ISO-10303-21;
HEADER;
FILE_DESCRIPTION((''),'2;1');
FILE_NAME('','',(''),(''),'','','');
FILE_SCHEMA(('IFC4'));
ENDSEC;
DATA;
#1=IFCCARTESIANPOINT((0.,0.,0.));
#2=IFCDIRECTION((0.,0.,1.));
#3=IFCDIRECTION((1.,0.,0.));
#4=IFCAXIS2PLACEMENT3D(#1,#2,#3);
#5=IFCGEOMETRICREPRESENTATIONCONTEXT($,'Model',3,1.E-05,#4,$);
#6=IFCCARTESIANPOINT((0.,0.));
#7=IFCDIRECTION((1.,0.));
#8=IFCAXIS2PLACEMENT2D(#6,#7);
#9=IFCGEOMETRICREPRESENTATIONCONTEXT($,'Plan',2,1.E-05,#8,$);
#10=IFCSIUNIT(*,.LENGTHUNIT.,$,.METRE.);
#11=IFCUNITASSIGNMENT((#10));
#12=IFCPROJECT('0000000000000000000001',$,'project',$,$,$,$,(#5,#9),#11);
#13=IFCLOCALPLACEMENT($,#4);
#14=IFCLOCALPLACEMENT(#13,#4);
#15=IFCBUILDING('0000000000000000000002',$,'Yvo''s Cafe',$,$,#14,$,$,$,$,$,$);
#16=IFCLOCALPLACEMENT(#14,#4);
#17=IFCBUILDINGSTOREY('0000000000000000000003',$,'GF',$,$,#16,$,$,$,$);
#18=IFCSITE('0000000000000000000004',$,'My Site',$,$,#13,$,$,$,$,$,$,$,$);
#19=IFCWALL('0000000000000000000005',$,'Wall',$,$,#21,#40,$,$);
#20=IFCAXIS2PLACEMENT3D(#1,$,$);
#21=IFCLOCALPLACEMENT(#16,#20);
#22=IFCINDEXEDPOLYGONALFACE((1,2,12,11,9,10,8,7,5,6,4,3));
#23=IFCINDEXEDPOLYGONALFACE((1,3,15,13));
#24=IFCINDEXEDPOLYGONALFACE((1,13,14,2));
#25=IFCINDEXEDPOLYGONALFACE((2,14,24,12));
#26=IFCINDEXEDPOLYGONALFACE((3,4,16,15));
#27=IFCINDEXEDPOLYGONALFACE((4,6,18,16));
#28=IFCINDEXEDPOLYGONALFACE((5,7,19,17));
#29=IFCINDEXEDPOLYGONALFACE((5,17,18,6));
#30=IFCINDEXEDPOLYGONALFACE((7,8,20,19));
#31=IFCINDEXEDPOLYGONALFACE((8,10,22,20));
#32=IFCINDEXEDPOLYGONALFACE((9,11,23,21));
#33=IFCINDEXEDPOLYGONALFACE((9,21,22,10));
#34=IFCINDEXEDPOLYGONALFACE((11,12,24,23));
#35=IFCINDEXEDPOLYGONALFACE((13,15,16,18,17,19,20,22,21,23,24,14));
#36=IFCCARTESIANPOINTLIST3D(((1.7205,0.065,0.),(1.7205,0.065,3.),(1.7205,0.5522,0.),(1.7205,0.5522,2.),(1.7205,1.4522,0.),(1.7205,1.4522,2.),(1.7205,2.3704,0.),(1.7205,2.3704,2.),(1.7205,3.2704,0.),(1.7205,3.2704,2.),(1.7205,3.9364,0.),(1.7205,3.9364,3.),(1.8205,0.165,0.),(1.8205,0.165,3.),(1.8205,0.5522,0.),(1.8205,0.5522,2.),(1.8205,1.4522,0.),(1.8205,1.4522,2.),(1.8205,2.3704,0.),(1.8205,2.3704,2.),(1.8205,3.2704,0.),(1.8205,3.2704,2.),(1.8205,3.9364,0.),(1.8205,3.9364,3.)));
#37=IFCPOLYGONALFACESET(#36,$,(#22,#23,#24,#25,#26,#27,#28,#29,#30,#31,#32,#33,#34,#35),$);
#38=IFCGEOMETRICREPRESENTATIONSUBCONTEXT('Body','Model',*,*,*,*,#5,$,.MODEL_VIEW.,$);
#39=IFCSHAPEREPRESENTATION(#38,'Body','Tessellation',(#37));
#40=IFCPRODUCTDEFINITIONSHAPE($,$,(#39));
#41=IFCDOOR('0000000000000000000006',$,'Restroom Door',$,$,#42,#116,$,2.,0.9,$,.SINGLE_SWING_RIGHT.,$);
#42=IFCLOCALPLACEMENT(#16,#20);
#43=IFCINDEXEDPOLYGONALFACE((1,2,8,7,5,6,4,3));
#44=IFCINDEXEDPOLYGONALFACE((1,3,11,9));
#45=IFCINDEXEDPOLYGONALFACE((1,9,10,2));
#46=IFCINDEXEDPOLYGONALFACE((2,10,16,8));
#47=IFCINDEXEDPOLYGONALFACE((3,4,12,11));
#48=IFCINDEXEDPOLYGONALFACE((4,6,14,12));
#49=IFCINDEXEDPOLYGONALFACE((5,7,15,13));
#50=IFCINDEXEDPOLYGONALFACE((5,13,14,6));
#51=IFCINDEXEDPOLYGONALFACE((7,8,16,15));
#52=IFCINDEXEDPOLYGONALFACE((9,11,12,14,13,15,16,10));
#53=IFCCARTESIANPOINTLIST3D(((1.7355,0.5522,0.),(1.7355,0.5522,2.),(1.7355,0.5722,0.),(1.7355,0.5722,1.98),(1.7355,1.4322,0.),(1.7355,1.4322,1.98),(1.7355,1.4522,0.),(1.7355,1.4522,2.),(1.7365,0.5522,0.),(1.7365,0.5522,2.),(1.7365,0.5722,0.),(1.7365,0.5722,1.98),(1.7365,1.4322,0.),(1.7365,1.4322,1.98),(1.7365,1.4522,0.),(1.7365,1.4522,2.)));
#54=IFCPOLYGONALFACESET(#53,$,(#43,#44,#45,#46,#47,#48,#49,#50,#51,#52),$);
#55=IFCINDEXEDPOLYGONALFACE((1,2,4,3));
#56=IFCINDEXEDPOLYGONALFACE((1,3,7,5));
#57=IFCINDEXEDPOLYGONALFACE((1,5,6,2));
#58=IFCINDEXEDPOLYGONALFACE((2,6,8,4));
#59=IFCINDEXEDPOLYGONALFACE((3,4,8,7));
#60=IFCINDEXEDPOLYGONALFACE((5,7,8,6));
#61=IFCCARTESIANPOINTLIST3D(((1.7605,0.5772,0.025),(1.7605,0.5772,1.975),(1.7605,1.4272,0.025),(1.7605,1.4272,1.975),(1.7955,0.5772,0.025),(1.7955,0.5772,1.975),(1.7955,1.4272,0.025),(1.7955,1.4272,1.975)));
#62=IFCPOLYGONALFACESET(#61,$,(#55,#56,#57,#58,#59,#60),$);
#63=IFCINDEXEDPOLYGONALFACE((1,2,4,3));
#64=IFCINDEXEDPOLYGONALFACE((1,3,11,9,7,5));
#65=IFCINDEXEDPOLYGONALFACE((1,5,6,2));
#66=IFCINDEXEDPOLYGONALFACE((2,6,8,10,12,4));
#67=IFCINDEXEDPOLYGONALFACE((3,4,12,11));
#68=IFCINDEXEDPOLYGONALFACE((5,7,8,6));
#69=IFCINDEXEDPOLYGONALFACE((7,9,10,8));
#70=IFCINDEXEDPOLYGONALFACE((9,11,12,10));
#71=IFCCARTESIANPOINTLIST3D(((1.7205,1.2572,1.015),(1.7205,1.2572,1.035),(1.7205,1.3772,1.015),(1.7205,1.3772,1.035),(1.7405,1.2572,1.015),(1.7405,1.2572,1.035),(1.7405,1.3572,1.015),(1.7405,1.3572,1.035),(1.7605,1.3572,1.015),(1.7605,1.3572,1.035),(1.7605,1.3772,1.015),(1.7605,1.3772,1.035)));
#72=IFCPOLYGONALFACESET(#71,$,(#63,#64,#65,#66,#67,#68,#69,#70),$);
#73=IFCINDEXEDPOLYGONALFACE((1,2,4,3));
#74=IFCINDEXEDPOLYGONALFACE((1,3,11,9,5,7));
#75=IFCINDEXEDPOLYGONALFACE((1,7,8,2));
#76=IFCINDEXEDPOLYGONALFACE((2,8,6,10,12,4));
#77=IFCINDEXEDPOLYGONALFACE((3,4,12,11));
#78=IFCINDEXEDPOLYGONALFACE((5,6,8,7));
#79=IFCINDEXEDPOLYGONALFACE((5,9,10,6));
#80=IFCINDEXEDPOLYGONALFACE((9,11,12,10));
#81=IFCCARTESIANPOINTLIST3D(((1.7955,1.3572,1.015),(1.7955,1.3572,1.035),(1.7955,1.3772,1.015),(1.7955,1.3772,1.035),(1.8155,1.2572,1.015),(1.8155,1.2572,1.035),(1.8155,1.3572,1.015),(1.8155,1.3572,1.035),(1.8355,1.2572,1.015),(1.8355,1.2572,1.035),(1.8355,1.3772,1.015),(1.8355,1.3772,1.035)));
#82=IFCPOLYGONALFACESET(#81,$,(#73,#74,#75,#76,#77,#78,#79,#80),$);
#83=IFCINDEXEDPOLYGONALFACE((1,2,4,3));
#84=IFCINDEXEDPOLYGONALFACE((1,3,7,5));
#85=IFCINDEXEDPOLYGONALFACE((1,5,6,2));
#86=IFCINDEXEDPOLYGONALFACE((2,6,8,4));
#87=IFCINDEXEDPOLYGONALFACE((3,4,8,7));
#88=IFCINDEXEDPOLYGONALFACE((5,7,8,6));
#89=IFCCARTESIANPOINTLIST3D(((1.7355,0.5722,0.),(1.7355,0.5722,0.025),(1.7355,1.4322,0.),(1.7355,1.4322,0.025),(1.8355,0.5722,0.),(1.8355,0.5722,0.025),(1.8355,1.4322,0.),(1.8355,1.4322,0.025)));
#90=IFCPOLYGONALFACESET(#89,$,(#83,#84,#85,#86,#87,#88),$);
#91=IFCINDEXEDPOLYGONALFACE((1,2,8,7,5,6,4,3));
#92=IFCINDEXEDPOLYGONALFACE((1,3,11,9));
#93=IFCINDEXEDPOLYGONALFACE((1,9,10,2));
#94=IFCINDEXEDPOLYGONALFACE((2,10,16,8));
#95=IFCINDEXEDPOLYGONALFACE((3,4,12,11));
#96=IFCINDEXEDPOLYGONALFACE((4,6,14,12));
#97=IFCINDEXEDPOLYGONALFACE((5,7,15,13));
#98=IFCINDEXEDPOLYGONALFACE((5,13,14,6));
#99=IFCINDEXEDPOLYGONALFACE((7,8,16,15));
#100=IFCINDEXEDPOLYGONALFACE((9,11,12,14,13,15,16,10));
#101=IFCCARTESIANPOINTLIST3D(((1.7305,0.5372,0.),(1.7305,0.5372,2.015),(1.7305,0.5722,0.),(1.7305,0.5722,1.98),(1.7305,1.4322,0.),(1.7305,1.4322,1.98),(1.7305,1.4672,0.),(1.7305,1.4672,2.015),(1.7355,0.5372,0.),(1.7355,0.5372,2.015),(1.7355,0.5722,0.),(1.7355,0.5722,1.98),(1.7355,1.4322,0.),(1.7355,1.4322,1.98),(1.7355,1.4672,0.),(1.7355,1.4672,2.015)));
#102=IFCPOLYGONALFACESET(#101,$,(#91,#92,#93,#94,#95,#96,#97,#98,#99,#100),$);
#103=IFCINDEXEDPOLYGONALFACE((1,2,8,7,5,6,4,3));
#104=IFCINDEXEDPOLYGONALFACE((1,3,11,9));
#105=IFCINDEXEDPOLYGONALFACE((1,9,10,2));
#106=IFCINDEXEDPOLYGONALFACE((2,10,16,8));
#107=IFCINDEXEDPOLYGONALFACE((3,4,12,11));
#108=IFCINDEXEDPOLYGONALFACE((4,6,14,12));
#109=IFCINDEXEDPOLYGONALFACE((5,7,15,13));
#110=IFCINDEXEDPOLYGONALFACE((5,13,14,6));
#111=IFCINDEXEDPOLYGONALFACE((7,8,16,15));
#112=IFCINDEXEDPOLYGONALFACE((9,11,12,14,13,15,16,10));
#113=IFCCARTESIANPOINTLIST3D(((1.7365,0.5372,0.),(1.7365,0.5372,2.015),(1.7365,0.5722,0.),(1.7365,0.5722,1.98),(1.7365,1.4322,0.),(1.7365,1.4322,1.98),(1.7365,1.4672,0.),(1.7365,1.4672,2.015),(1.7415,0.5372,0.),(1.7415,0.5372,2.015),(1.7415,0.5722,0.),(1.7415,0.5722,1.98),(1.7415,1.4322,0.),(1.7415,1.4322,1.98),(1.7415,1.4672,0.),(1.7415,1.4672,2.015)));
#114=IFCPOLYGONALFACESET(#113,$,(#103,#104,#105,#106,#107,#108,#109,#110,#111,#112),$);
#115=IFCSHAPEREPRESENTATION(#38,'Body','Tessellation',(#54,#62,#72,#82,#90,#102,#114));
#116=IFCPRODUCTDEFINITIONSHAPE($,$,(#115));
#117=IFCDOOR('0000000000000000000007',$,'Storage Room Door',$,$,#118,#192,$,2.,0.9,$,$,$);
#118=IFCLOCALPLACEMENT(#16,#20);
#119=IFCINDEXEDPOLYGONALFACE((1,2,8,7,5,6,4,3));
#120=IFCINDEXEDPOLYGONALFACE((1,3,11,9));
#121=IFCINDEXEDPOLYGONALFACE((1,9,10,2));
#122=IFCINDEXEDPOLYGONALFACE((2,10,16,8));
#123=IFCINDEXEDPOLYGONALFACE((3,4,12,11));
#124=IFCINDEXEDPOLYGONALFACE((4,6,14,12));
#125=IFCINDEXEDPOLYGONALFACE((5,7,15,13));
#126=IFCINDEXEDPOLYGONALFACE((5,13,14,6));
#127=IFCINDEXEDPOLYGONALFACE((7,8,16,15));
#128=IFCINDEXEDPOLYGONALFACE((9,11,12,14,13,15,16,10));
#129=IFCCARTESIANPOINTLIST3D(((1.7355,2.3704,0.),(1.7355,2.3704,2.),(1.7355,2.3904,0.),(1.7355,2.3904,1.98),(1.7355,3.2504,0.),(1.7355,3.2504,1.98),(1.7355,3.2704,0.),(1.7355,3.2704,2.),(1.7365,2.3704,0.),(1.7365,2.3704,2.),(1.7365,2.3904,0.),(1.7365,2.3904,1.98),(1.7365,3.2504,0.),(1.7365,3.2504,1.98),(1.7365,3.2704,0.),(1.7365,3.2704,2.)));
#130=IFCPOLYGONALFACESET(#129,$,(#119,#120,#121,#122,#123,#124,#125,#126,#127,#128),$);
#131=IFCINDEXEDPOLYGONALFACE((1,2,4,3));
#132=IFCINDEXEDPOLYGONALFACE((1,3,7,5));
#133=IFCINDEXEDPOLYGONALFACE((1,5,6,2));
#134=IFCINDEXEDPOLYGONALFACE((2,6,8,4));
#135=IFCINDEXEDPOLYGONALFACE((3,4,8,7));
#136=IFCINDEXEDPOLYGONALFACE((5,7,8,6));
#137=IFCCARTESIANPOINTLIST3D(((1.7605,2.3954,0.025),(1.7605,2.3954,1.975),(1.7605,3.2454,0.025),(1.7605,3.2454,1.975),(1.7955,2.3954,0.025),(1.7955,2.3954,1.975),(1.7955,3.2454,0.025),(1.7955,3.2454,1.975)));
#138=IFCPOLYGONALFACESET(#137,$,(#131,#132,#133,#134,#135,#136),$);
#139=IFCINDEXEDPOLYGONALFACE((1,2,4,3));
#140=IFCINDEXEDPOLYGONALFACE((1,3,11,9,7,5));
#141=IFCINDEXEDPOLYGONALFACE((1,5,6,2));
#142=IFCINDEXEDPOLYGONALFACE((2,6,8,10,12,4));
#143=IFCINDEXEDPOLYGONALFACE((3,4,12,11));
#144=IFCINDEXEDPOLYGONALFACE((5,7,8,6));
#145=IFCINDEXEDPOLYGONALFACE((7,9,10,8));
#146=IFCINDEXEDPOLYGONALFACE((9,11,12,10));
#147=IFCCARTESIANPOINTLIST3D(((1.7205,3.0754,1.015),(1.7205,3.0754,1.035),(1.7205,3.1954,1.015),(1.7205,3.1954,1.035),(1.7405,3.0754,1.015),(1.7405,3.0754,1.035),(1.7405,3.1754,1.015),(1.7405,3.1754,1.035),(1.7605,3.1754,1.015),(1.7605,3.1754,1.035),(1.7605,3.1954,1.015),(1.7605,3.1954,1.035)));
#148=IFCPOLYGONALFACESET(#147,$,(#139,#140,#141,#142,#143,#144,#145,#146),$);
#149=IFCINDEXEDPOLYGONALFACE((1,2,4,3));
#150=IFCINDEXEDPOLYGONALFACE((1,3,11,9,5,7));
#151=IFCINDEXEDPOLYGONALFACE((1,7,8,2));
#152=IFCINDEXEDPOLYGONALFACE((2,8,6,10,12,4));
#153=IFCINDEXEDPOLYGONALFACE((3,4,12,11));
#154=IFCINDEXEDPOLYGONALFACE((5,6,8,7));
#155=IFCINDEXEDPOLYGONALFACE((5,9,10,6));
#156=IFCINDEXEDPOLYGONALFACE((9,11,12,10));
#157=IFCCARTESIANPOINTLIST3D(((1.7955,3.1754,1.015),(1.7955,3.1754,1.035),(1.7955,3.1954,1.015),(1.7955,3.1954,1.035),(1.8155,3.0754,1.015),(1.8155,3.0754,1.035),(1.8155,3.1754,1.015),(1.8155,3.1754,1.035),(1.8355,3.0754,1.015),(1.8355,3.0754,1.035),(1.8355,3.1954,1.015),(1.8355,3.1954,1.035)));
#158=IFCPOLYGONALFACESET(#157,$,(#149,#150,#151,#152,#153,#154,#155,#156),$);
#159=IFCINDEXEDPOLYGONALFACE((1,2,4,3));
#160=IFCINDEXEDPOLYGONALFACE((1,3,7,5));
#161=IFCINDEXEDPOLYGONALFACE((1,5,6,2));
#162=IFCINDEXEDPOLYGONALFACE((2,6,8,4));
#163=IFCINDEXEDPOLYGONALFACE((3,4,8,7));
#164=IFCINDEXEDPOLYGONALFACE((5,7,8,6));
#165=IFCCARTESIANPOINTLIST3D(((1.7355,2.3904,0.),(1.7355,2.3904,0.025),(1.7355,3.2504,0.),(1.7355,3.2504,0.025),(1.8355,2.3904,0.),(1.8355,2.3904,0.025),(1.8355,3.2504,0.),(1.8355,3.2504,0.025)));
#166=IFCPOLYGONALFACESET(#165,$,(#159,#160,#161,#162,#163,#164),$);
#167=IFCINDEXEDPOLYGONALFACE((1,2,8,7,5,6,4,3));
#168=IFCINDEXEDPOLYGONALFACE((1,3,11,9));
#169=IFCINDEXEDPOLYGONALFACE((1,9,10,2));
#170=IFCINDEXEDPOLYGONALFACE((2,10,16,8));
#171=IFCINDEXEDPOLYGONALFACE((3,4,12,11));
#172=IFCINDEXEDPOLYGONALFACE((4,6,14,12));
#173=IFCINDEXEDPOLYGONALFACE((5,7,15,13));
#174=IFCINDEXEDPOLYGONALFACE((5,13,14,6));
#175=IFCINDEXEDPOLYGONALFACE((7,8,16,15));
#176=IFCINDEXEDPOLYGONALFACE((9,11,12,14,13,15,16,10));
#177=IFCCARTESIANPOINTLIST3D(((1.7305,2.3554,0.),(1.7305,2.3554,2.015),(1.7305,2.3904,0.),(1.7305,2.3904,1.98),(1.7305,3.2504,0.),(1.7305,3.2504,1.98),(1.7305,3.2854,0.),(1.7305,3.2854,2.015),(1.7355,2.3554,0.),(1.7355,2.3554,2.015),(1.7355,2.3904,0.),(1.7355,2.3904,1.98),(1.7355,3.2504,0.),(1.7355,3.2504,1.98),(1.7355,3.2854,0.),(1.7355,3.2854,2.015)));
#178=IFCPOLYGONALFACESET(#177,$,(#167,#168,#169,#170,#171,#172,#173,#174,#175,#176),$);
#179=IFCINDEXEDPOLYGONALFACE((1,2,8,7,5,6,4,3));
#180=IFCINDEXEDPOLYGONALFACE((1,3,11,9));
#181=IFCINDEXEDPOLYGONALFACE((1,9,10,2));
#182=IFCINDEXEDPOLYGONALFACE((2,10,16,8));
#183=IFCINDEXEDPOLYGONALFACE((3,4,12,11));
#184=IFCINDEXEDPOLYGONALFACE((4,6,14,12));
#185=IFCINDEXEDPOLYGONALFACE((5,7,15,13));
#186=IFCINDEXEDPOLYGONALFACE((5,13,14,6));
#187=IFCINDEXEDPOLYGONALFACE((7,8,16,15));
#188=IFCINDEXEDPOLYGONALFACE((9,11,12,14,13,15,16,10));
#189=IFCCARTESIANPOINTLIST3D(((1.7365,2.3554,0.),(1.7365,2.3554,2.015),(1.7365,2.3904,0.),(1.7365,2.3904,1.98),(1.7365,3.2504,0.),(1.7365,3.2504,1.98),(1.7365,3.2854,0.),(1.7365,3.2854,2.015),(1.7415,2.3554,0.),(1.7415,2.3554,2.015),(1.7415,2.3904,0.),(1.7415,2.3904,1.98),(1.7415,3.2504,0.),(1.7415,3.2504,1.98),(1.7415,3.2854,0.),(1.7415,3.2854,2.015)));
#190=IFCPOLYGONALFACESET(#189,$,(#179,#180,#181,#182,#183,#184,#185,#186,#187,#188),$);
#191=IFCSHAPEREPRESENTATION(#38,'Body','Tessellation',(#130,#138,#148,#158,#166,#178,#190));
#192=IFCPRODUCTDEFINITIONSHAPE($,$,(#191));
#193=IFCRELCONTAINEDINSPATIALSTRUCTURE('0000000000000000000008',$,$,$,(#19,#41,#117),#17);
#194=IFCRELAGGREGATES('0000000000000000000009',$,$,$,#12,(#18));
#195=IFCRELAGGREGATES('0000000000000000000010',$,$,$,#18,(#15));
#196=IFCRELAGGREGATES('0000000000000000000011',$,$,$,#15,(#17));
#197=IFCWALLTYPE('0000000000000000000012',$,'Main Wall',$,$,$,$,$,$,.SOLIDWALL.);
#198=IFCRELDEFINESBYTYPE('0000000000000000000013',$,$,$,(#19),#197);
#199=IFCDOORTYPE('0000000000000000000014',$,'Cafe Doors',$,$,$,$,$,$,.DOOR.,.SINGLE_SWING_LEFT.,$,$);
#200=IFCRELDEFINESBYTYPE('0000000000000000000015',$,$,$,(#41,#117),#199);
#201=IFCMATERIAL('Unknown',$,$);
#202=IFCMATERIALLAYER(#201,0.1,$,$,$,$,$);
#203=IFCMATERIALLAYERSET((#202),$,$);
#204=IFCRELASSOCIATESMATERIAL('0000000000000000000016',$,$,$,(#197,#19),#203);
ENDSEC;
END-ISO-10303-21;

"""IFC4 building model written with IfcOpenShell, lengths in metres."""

from ifc_helpers import new_model, entity, si_unit, frame, origin_with_axes, origin_2d_with_axis, place, context, subcontext, project, spatial, line, indexed_curve, outline, extrude, shape, source, transform, mapped, material, layer, layer_set, layer_usage, type_object, type_shapes, element, fill, save


model = new_model("IFC4")

# Units and contexts
model_context = context("Model", 3, precision=1e-05, world=origin_with_axes())
plan_context = context("Plan", 2, precision=1e-05, world=origin_2d_with_axis())
body_context_1 = subcontext(model_context, "Body", "Model", "MODEL_VIEW")
body_context_2 = subcontext(plan_context, "Body", "Plan", "PLAN_VIEW")
ifc_project = project(units=[si_unit("LENGTHUNIT", "METRE")], contexts=[model_context, plan_context])

# Site, building, storey
site_placement = place(None, origin_with_axes())
site = spatial("IfcSite", under=ifc_project, at=site_placement, Name="My Site")
building_placement = place(site_placement, origin_with_axes())
building = spatial("IfcBuilding", under=site, at=building_placement, Name="Yvo's Cafe")
storey_placement = place(building_placement, origin_with_axes())
storey = spatial("IfcBuildingStorey", under=building, at=storey_placement, Name="GF")

# Shared definitions
ifc_material = material(Name="Unknown")

# Shared definitions
ifc_layer_1 = layer(ifc_material, 0.1)
ifc_layer_set_1 = layer_set([ifc_layer_1])
wall_type = type_object("IfcWallType", Name="Main Wall", PredefinedType="SOLIDWALL", material=ifc_layer_set_1)

# Wall, openings, doors
ifc_layer_usage_1 = layer_usage(ifc_layer_set_1, "AXIS2", "POSITIVE", 0.0)
wall_1_placement = place(storey_placement, frame((1.7205, 3.9364, 0.0), z_axis=(0.0, 0.0, 1.0), x_axis=(0.0, -1.0, 0.0)))
wall_1 = element("IfcWall", 1, at=wall_1_placement, inside=storey, type_object=wall_type, material=ifc_layer_usage_1, Name="Wall", context=body_context_1, shape_type="SweptSolid", body=[
    extrude(outline(indexed_curve([(0.0, 0.0), (0.0, 0.1), (3.7713, 0.1), (3.8713, 0.0)], segments=[line(1, 2, 3, 4, 1)])), origin_with_axes(), (0.0, 0.0, 1.0), 3.0),
])
shared_shape_1 = source(origin_with_axes(), body_context_1, "Body", "SweptSolid", [
    extrude(outline(indexed_curve([(0.0, 0.0), (0.9, 0.0), (0.9, 2.0), (0.0, 2.0)], segments=[line(1, 2, 3, 4, 1)])), frame((0.0, -0.6, 0.0), z_axis=(0.0, -1.0, 0.0), x_axis=(1.0, 0.0, 0.0)), (0.0, 0.0, -1.0), 1.2),
])
opening_1_placement = place(wall_1_placement, frame((2.4842, 0.015, 0.0), z_axis=(0.0, 0.0, 1.0), x_axis=(1.0, 0.0, 0.0)))
opening_1 = element("IfcOpeningElement", 2, at=opening_1_placement, cuts=wall_1, PredefinedType="OPENING", context=body_context_1, shape_type="MappedRepresentation", body=[
    mapped(shared_shape_1, transform((0.0, 0.0, 0.0), x_axis=(1.0, 0.0, 0.0), y_axis=(0.0, 1.0, 0.0), z_axis=(0.0, 0.0, 1.0), scale=1.0)),
])
opening_2_placement = place(wall_1_placement, frame((1.566, 0.1, 0.0), z_axis=(0.0, 0.0, 1.0), x_axis=(-1.0, 0.0, 0.0)))
opening_2 = element("IfcOpeningElement", 3, at=opening_2_placement, cuts=wall_1, PredefinedType="OPENING", context=body_context_1, shape_type="MappedRepresentation", body=[
    mapped(shared_shape_1, transform((0.0, 0.0, 0.0), x_axis=(1.0, 0.0, 0.0), y_axis=(0.0, 1.0, 0.0), z_axis=(0.0, 0.0, 1.0), scale=1.0)),
])
door_type_1 = type_object("IfcDoorType", Name="Cafe Doors", OperationType="SINGLE_SWING_LEFT", PredefinedType="DOOR")
shared_shape_2 = source(origin_with_axes(), body_context_1, "Body", "SweptSolid", [
    extrude(outline(indexed_curve([(0.0, 0.0), (0.0, 2.0), (0.9, 2.0), (0.9, 0.0), (0.88, 0.0), (0.88, 1.98), (0.02, 1.98), (0.02, 0.0)], segments=[line(1, 2, 3, 4, 5, 6, 7, 8, 1)])), frame((0.0, 0.0, 0.0), z_axis=(0.0, -1.0, 0.0), x_axis=(1.0, 0.0, 0.0)), (0.0, 0.0, -1.0), 0.001),
    extrude(outline(indexed_curve([(0.0, 0.0), (0.85, 0.0), (0.85, 0.035), (0.0, 0.035)], segments=[line(1, 2, 3, 4, 1)])), frame((0.025, 0.025, 0.025), z_axis=(0.0, 0.0, 1.0), x_axis=(1.0, 0.0, 0.0)), (0.0, 0.0, 1.0), 1.95),
    extrude(outline(indexed_curve([(0.0, 0.0), (0.0, -0.04), (0.12, -0.04), (0.12, -0.02), (0.02, -0.02), (0.02, 0.0)], segments=[line(1, 2, 3, 4, 5, 6, 1)])), frame((0.075, 0.025, 1.015), z_axis=(0.0, 0.0, 1.0), x_axis=(1.0, 0.0, 0.0)), (0.0, 0.0, 1.0), 0.02),
    extrude(outline(indexed_curve([(0.0, 0.0), (0.0, 0.04), (0.12, 0.04), (0.12, 0.02), (0.02, 0.02), (0.02, 0.0)], segments=[line(1, 2, 3, 4, 5, 6, 1)])), frame((0.075, 0.06, 1.015), z_axis=(0.0, 0.0, 1.0), x_axis=(1.0, 0.0, 0.0)), (0.0, 0.0, 1.0), 0.02),
    extrude(outline(indexed_curve([(0.0, 0.0), (0.86, 0.0), (0.86, 0.1), (0.0, 0.1)], segments=[line(1, 2, 3, 4, 1)])), frame((0.02, 0.0, 0.0), z_axis=(0.0, 0.0, 1.0), x_axis=(1.0, 0.0, 0.0)), (0.0, 0.0, 1.0), 0.025),
    extrude(outline(indexed_curve([(0.0, 0.0), (0.0, 2.015), (0.93, 2.015), (0.93, 0.0), (0.895, 0.0), (0.895, 1.98), (0.035, 1.98), (0.035, 0.0)], segments=[line(1, 2, 3, 4, 5, 6, 7, 8, 1)])), frame((-0.015, -0.005, 0.0), z_axis=(0.0, -1.0, 0.0), x_axis=(1.0, 0.0, 0.0)), (0.0, 0.0, -1.0), 0.005),
    extrude(outline(indexed_curve([(0.0, 0.0), (0.0, 2.015), (0.93, 2.015), (0.93, 0.0), (0.895, 0.0), (0.895, 1.98), (0.035, 1.98), (0.035, 0.0)], segments=[line(1, 2, 3, 4, 5, 6, 7, 8, 1)])), frame((-0.015, 0.001, 0.0), z_axis=(0.0, -1.0, 0.0), x_axis=(1.0, 0.0, 0.0)), (0.0, 0.0, -1.0), 0.005),
])
shared_shape_3 = source(origin_with_axes(), body_context_2, "Body", "Curve2D", [
    entity("IfcIndexedPolyCurve", entity("IfcCartesianPointList2D", [[0.0, 0.0], [0.02, 0.0], [0.02, 0.001], [0.0, 0.001]]), [entity("IfcLineIndex", [1, 2, 3, 4, 1])]),
    entity("IfcIndexedPolyCurve", entity("IfcCartesianPointList2D", [[0.9, 0.0], [0.88, 0.0], [0.88, 0.001], [0.9, 0.001]]), [entity("IfcLineIndex", [1, 2, 3, 4, 1])]),
    entity("IfcTrimmedCurve", entity("IfcEllipse", entity("IfcAxis2Placement2D", entity("IfcCartesianPoint", [0.84, 0.001]), entity("IfcDirection", [1.0, 0.0])), 0.815, 0.85), [entity("IfcCartesianPoint", [0.84, 0.851])], [entity("IfcCartesianPoint", [0.025, 0.001])], True, "CARTESIAN"),
    entity("IfcIndexedPolyCurve", entity("IfcCartesianPointList2D", [[0.875, 0.001], [0.84, 0.001], [0.84, 0.851], [0.875, 0.851]]), [entity("IfcLineIndex", [1, 2, 3, 4, 1])]),
])
type_shapes(door_type_1, [shared_shape_2, shared_shape_3])
door_1_placement = place(opening_1_placement, frame((0.0, 0.0, 0.0), z_axis=(0.0, 0.0, 1.0), x_axis=(1.0, 0.0, 0.0)))
door_1 = element("IfcDoor", 4, at=door_1_placement, inside=storey, type_object=door_type_1, Name="Restroom Door", OperationType="SINGLE_SWING_RIGHT", OverallHeight=2.0, OverallWidth=0.9, shapes=[
    shape(body_context_1, "Body", "MappedRepresentation", [mapped(shared_shape_2, transform((0.0, 0.0, 0.0), x_axis=(1.0, 0.0, 0.0), y_axis=(0.0, 1.0, 0.0), z_axis=(0.0, 0.0, 1.0), scale=1.0))]),
    shape(body_context_2, "Body", "MappedRepresentation", [mapped(shared_shape_3, transform((0.0, 0.0, 0.0), x_axis=(1.0, 0.0, 0.0), y_axis=(0.0, 1.0, 0.0), z_axis=(0.0, 0.0, 1.0), scale=1.0))]),
])
fill(opening_1, door_1)
door_2_placement = place(opening_2_placement, frame((0.9, 0.085, 0.0), z_axis=(0.0, 0.0, 1.0), x_axis=(-1.0, 0.0, 0.0)))
door_2 = element("IfcDoor", 5, at=door_2_placement, inside=storey, type_object=door_type_1, Name="Storage Room Door", OverallHeight=2.0, OverallWidth=0.9, shapes=[
    shape(body_context_1, "Body", "MappedRepresentation", [mapped(shared_shape_2, transform((0.0, 0.0, 0.0), x_axis=(1.0, 0.0, 0.0), y_axis=(0.0, 1.0, 0.0), z_axis=(0.0, 0.0, 1.0), scale=1.0))]),
    shape(body_context_2, "Body", "MappedRepresentation", [mapped(shared_shape_3, transform((0.0, 0.0, 0.0), x_axis=(1.0, 0.0, 0.0), y_axis=(0.0, 1.0, 0.0), z_axis=(0.0, 0.0, 1.0), scale=1.0))]),
])
fill(opening_2, door_2)

save(model, "model.ifc")
